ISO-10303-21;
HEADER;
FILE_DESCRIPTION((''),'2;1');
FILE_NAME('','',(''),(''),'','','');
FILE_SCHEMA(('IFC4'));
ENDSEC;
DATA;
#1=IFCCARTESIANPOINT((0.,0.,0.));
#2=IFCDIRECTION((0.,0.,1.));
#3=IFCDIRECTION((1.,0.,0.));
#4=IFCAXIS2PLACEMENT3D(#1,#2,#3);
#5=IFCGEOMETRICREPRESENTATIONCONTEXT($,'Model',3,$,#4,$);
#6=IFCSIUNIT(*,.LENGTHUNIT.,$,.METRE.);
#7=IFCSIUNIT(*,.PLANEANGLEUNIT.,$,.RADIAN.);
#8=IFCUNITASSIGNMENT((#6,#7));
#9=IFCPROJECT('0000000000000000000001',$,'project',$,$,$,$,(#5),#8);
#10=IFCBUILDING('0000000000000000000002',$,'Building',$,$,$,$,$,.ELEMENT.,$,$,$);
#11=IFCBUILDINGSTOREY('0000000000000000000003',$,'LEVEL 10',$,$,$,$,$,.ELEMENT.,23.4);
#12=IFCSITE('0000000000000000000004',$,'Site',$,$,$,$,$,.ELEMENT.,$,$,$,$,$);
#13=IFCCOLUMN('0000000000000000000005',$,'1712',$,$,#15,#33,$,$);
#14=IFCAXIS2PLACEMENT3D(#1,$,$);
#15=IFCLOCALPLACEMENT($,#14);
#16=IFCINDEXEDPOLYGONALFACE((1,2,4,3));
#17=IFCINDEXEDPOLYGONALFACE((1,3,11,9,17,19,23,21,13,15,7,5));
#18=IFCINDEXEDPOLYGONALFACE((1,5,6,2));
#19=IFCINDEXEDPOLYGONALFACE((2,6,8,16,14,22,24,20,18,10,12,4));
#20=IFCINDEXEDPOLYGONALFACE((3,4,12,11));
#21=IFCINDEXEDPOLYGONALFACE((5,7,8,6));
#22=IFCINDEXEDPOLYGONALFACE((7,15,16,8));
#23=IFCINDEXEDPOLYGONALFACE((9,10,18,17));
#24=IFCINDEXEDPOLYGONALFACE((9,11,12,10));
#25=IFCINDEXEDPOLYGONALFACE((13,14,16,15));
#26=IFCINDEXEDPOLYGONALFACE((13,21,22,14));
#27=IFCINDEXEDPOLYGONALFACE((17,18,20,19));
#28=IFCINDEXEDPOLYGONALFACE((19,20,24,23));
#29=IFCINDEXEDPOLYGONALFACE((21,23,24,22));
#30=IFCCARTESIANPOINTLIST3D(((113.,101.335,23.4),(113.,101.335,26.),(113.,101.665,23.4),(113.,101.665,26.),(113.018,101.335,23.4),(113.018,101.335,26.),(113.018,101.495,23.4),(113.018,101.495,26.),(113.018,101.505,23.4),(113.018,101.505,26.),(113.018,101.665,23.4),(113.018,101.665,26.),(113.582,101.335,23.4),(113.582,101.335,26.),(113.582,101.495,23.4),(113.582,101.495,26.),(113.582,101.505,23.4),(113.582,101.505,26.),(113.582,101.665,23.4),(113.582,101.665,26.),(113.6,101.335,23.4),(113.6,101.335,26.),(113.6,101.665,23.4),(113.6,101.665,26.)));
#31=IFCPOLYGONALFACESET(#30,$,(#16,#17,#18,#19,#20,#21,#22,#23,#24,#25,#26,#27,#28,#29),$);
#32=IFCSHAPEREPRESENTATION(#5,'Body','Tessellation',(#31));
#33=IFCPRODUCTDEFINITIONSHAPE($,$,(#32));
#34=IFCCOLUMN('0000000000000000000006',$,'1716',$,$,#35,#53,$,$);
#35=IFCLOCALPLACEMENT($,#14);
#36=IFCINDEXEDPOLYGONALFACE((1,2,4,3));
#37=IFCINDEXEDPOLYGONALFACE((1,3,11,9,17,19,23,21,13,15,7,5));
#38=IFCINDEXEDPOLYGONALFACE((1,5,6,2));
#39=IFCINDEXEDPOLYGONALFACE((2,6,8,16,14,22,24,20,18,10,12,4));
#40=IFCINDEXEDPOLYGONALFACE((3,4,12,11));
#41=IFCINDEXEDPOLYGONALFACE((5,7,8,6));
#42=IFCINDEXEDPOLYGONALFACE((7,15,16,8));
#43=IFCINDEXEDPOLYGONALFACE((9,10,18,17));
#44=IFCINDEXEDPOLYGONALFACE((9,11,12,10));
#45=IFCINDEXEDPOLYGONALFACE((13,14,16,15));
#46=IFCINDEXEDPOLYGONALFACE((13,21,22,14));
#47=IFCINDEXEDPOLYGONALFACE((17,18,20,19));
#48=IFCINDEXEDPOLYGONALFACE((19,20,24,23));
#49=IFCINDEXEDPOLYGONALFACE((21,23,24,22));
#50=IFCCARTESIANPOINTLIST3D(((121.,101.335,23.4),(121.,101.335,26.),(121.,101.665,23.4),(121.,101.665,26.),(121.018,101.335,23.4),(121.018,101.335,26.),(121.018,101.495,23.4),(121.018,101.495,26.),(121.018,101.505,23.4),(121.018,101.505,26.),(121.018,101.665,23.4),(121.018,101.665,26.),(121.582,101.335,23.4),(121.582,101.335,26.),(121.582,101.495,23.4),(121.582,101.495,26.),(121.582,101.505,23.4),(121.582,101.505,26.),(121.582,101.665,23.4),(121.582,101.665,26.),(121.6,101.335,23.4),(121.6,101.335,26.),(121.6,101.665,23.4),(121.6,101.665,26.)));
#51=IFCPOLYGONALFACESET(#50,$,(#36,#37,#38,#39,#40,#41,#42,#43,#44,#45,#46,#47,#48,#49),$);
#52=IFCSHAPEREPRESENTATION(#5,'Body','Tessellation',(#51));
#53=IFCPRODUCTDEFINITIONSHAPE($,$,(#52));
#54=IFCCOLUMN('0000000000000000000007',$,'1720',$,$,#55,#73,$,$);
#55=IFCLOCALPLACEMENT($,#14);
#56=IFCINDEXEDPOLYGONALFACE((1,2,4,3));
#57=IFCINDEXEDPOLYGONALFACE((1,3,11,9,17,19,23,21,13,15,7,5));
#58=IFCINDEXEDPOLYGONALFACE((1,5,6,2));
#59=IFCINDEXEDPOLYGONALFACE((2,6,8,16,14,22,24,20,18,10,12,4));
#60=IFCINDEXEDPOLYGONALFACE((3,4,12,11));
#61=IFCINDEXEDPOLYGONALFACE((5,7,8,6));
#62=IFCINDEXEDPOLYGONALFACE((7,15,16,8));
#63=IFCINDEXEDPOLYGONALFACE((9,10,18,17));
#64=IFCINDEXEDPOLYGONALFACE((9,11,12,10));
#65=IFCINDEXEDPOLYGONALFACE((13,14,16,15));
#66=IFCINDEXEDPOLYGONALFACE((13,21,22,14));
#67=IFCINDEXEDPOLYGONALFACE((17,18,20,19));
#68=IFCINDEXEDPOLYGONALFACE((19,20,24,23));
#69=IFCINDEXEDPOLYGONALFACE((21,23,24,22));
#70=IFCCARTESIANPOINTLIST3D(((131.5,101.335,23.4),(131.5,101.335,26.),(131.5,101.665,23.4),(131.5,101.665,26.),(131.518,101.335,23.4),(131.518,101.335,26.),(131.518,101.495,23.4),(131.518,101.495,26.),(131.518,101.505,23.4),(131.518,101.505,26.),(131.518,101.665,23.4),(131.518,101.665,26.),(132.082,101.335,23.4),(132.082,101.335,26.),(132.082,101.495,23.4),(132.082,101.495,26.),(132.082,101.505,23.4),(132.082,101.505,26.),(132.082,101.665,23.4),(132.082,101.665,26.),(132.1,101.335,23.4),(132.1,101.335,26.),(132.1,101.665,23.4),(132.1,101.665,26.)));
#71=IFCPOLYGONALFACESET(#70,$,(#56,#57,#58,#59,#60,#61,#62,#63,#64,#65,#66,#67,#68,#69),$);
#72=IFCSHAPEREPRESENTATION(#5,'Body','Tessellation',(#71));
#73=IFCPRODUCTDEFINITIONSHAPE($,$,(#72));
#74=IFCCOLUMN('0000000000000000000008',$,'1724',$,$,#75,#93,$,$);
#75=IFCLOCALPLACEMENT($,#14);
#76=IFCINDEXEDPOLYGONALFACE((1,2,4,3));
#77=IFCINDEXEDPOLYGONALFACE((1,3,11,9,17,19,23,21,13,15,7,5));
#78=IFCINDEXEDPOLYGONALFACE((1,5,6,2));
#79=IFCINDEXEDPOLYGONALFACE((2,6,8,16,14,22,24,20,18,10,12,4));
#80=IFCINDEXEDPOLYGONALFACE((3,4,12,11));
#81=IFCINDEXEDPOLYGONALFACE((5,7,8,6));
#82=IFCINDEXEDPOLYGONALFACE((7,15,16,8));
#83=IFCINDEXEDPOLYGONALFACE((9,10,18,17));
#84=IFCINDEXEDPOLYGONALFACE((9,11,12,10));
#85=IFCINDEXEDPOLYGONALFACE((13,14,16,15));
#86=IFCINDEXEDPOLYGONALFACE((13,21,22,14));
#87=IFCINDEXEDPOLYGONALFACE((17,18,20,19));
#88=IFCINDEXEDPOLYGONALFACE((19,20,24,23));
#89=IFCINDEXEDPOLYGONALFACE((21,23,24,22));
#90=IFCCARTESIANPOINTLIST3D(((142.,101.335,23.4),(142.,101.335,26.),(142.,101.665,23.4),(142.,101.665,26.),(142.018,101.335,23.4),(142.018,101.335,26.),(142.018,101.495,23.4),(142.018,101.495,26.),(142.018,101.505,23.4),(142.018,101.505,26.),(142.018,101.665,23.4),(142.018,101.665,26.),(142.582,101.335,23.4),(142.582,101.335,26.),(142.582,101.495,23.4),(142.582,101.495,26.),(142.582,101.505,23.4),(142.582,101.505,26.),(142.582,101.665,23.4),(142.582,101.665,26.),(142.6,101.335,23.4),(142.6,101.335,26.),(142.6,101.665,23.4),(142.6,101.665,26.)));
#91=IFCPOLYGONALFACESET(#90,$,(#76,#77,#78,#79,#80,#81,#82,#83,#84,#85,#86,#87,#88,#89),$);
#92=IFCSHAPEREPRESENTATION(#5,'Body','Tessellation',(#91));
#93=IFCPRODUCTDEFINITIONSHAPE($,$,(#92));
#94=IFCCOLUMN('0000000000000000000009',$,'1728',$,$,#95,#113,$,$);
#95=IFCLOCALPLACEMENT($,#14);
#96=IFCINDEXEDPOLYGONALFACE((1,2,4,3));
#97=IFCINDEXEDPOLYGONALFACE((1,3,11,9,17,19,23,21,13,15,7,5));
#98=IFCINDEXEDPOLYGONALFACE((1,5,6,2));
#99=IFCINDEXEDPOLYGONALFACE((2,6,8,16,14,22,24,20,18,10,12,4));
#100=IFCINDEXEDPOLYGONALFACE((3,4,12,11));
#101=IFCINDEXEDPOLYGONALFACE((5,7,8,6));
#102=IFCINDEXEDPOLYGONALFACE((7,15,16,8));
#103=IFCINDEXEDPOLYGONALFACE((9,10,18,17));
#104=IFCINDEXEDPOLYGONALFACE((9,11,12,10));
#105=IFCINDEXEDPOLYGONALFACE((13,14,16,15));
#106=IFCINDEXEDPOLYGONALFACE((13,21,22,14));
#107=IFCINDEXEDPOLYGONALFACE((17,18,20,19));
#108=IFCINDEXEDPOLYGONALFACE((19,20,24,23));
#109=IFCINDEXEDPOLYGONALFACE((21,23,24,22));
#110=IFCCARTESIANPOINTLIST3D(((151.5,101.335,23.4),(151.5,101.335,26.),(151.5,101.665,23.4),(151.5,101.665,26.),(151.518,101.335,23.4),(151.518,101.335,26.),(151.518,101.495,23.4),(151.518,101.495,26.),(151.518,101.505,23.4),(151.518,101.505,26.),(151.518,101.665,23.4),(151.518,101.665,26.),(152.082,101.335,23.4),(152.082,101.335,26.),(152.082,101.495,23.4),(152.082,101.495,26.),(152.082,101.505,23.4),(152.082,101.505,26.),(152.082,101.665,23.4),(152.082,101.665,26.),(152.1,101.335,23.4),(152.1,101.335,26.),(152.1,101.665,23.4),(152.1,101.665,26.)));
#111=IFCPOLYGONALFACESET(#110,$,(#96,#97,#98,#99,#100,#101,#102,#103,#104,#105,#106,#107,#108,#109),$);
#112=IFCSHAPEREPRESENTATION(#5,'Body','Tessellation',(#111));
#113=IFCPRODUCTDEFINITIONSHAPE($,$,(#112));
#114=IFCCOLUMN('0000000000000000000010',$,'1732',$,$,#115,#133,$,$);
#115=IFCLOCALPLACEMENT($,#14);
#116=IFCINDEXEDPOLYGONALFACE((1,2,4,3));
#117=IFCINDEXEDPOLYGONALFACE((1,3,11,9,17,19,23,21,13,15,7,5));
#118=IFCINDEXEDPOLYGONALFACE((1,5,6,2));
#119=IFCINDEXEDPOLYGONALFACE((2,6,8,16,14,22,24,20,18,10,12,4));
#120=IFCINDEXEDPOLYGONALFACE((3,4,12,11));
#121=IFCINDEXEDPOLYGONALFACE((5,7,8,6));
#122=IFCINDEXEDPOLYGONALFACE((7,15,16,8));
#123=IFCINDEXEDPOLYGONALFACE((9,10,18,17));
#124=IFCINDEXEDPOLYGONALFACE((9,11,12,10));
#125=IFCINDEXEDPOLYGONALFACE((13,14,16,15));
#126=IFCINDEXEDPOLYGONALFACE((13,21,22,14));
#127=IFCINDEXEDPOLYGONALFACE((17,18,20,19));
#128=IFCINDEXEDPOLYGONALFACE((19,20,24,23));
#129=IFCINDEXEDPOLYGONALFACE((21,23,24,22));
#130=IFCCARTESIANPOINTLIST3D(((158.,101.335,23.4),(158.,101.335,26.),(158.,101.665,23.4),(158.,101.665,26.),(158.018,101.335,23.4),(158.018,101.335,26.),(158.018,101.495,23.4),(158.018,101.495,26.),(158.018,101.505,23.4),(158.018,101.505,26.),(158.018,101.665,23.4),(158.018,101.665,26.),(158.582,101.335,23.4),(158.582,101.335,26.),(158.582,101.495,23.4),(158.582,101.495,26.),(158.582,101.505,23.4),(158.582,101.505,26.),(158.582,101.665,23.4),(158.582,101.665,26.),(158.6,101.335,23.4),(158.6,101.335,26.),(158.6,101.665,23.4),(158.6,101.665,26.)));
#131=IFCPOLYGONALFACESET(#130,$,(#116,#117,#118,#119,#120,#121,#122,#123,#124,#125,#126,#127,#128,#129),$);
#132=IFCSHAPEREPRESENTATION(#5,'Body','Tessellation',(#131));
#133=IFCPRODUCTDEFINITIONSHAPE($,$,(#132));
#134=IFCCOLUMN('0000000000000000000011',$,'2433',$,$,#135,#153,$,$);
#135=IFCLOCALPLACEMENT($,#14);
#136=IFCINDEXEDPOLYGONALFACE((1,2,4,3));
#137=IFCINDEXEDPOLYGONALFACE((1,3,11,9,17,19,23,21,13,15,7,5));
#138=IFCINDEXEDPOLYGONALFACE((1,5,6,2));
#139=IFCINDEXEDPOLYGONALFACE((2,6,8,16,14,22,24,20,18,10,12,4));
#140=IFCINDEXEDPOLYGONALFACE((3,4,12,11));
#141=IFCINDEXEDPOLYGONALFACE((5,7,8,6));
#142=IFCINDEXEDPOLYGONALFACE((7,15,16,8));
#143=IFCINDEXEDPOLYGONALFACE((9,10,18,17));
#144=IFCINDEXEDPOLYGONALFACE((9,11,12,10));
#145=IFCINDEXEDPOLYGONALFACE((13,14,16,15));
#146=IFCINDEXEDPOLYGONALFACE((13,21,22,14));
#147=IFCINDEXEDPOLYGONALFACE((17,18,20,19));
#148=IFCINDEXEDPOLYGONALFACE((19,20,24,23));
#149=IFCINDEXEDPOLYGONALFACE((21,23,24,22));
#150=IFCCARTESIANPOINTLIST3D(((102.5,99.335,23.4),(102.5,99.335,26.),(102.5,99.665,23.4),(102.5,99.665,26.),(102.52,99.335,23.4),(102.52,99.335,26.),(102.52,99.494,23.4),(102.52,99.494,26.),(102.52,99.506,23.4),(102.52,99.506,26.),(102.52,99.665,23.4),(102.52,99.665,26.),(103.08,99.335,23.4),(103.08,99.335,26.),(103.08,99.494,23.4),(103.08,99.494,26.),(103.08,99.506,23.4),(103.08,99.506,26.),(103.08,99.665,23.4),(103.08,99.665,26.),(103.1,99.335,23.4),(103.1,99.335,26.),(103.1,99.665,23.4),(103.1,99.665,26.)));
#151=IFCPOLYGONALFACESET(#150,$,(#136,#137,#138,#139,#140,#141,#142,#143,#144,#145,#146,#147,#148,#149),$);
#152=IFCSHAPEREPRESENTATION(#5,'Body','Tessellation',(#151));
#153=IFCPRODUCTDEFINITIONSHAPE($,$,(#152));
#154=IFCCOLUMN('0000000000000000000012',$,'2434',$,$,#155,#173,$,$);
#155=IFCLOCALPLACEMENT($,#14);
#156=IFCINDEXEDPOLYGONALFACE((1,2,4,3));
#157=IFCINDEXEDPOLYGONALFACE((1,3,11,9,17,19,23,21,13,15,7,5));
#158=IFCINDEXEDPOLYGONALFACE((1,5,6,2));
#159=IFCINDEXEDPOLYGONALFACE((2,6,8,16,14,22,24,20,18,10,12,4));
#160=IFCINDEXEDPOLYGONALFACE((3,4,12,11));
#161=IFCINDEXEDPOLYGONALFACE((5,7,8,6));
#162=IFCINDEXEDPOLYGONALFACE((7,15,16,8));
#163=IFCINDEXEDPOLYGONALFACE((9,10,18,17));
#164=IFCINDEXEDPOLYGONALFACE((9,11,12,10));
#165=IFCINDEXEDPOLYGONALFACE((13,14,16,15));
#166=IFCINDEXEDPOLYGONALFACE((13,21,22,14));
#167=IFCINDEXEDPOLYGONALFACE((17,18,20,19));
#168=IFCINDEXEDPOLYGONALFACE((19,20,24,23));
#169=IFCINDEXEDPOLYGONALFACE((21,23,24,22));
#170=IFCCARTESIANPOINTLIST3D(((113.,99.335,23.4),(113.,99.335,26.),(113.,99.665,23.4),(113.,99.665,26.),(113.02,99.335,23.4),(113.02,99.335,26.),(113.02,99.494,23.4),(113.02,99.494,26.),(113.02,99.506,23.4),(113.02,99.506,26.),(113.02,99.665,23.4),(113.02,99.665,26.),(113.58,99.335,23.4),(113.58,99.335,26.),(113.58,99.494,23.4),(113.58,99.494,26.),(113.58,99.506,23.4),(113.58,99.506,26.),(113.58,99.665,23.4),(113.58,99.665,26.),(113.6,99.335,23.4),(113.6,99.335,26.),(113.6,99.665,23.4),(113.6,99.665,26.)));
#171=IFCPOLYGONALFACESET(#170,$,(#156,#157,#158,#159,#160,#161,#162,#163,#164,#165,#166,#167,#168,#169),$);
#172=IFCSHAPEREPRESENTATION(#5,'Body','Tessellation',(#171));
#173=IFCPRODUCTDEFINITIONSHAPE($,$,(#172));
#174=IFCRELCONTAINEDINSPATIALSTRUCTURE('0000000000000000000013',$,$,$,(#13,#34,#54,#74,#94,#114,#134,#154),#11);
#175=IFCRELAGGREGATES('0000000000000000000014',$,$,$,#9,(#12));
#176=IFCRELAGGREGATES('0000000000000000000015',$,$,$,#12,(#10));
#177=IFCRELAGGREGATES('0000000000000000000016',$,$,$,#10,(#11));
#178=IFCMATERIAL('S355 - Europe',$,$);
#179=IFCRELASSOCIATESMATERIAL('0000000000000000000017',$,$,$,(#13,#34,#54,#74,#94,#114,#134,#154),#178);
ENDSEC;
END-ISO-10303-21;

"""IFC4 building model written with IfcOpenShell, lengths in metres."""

from ifc_helpers import new_model, si_unit, frame, origin_with_axes, origin_2d_with_axis, place, context, project, spatial, i_section, extrude, material, material_profile, profile_set, profile_usage, element, save


model = new_model("IFC4")

# Units and contexts
model_context = context("Model", 3, world=origin_with_axes())
ifc_project = project(units=[si_unit("LENGTHUNIT", "METRE"), si_unit("PLANEANGLEUNIT", "RADIAN")], contexts=[model_context])

# Site, building, storey
site = spatial("IfcSite", under=ifc_project, Name="Site", CompositionType="ELEMENT")
building = spatial("IfcBuilding", under=site, Name="Building", CompositionType="ELEMENT")
storey = spatial("IfcBuildingStorey", under=building, Name="LEVEL 10", CompositionType="ELEMENT", Elevation=23.4)

# Columns
ifc_material = material(Name="S355 - Europe")
ifc_material_profile_1 = material_profile(ifc_material, i_section(OverallWidth=0.33, OverallDepth=0.6, WebThickness=0.01, FlangeThickness=0.018, at=origin_2d_with_axis()))
ifc_profile_set_1 = profile_set([ifc_material_profile_1])
ifc_profile_usage_1 = profile_usage(ifc_profile_set_1, cardinal=10)
column_1_placement = place(None, frame((113.3, 101.5, 23.4), z_axis=(0.0, 0.0, 1.0), x_axis=(0.0, -1.0, 0.0)))
element("IfcColumn", 1, at=column_1_placement, inside=storey, material=ifc_profile_usage_1, Name="1712", context=model_context, shape_type="SweptSolid", body=[
    extrude(i_section(OverallWidth=0.33, OverallDepth=0.6, WebThickness=0.01, FlangeThickness=0.018, at=origin_2d_with_axis()), origin_with_axes(), (0.0, 0.0, 1.0), 2.6),
])
ifc_material_profile_2 = material_profile(ifc_material, i_section(OverallWidth=0.33, OverallDepth=0.6, WebThickness=0.01, FlangeThickness=0.018, at=origin_2d_with_axis()))
ifc_profile_set_2 = profile_set([ifc_material_profile_2])
ifc_profile_usage_2 = profile_usage(ifc_profile_set_2, cardinal=10)
column_2_placement = place(None, frame((121.3, 101.5, 23.4), z_axis=(0.0, 0.0, 1.0), x_axis=(0.0, -1.0, 0.0)))
element("IfcColumn", 2, at=column_2_placement, inside=storey, material=ifc_profile_usage_2, Name="1716", context=model_context, shape_type="SweptSolid", body=[
    extrude(i_section(OverallWidth=0.33, OverallDepth=0.6, WebThickness=0.01, FlangeThickness=0.018, at=origin_2d_with_axis()), origin_with_axes(), (0.0, 0.0, 1.0), 2.6),
])
ifc_material_profile_3 = material_profile(ifc_material, i_section(OverallWidth=0.33, OverallDepth=0.6, WebThickness=0.01, FlangeThickness=0.018, at=origin_2d_with_axis()))
ifc_profile_set_3 = profile_set([ifc_material_profile_3])
ifc_profile_usage_3 = profile_usage(ifc_profile_set_3, cardinal=10)
column_3_placement = place(None, frame((131.8, 101.5, 23.4), z_axis=(0.0, 0.0, 1.0), x_axis=(0.0, -1.0, 0.0)))
element("IfcColumn", 3, at=column_3_placement, inside=storey, material=ifc_profile_usage_3, Name="1720", context=model_context, shape_type="SweptSolid", body=[
    extrude(i_section(OverallWidth=0.33, OverallDepth=0.6, WebThickness=0.01, FlangeThickness=0.018, at=origin_2d_with_axis()), origin_with_axes(), (0.0, 0.0, 1.0), 2.6),
])
ifc_material_profile_4 = material_profile(ifc_material, i_section(OverallWidth=0.33, OverallDepth=0.6, WebThickness=0.01, FlangeThickness=0.018, at=origin_2d_with_axis()))
ifc_profile_set_4 = profile_set([ifc_material_profile_4])
ifc_profile_usage_4 = profile_usage(ifc_profile_set_4, cardinal=10)
column_4_placement = place(None, frame((142.3, 101.5, 23.4), z_axis=(0.0, 0.0, 1.0), x_axis=(0.0, -1.0, 0.0)))
element("IfcColumn", 4, at=column_4_placement, inside=storey, material=ifc_profile_usage_4, Name="1724", context=model_context, shape_type="SweptSolid", body=[
    extrude(i_section(OverallWidth=0.33, OverallDepth=0.6, WebThickness=0.01, FlangeThickness=0.018, at=origin_2d_with_axis()), origin_with_axes(), (0.0, 0.0, 1.0), 2.6),
])
ifc_material_profile_5 = material_profile(ifc_material, i_section(OverallWidth=0.33, OverallDepth=0.6, WebThickness=0.01, FlangeThickness=0.018, at=origin_2d_with_axis()))
ifc_profile_set_5 = profile_set([ifc_material_profile_5])
ifc_profile_usage_5 = profile_usage(ifc_profile_set_5, cardinal=10)
column_5_placement = place(None, frame((151.8, 101.5, 23.4), z_axis=(0.0, 0.0, 1.0), x_axis=(0.0, -1.0, 0.0)))
element("IfcColumn", 5, at=column_5_placement, inside=storey, material=ifc_profile_usage_5, Name="1728", context=model_context, shape_type="SweptSolid", body=[
    extrude(i_section(OverallWidth=0.33, OverallDepth=0.6, WebThickness=0.01, FlangeThickness=0.018, at=origin_2d_with_axis()), origin_with_axes(), (0.0, 0.0, 1.0), 2.6),
])
ifc_material_profile_6 = material_profile(ifc_material, i_section(OverallWidth=0.33, OverallDepth=0.6, WebThickness=0.01, FlangeThickness=0.018, at=origin_2d_with_axis()))
ifc_profile_set_6 = profile_set([ifc_material_profile_6])
ifc_profile_usage_6 = profile_usage(ifc_profile_set_6, cardinal=10)
column_6_placement = place(None, frame((158.3, 101.5, 23.4), z_axis=(0.0, 0.0, 1.0), x_axis=(0.0, -1.0, 0.0)))
element("IfcColumn", 6, at=column_6_placement, inside=storey, material=ifc_profile_usage_6, Name="1732", context=model_context, shape_type="SweptSolid", body=[
    extrude(i_section(OverallWidth=0.33, OverallDepth=0.6, WebThickness=0.01, FlangeThickness=0.018, at=origin_2d_with_axis()), origin_with_axes(), (0.0, 0.0, 1.0), 2.6),
])
ifc_material_profile_7 = material_profile(ifc_material, i_section(OverallWidth=0.33, OverallDepth=0.6, WebThickness=0.012, FlangeThickness=0.02, at=origin_2d_with_axis()))
ifc_profile_set_7 = profile_set([ifc_material_profile_7])
ifc_profile_usage_7 = profile_usage(ifc_profile_set_7, cardinal=10)
column_7_placement = place(None, frame((102.8, 99.5, 23.4), z_axis=(0.0, 0.0, 1.0), x_axis=(0.0, -1.0, 0.0)))
element("IfcColumn", 7, at=column_7_placement, inside=storey, material=ifc_profile_usage_7, Name="2433", context=model_context, shape_type="SweptSolid", body=[
    extrude(i_section(OverallWidth=0.33, OverallDepth=0.6, WebThickness=0.012, FlangeThickness=0.02, at=origin_2d_with_axis()), origin_with_axes(), (0.0, 0.0, 1.0), 2.6),
])
ifc_material_profile_8 = material_profile(ifc_material, i_section(OverallWidth=0.33, OverallDepth=0.6, WebThickness=0.012, FlangeThickness=0.02, at=origin_2d_with_axis()))
ifc_profile_set_8 = profile_set([ifc_material_profile_8])
ifc_profile_usage_8 = profile_usage(ifc_profile_set_8, cardinal=10)
column_8_placement = place(None, frame((113.3, 99.5, 23.4), z_axis=(0.0, 0.0, 1.0), x_axis=(0.0, -1.0, 0.0)))
element("IfcColumn", 8, at=column_8_placement, inside=storey, material=ifc_profile_usage_8, Name="2434", context=model_context, shape_type="SweptSolid", body=[
    extrude(i_section(OverallWidth=0.33, OverallDepth=0.6, WebThickness=0.012, FlangeThickness=0.02, at=origin_2d_with_axis()), origin_with_axes(), (0.0, 0.0, 1.0), 2.6),
])

save(model, "model.ifc")
